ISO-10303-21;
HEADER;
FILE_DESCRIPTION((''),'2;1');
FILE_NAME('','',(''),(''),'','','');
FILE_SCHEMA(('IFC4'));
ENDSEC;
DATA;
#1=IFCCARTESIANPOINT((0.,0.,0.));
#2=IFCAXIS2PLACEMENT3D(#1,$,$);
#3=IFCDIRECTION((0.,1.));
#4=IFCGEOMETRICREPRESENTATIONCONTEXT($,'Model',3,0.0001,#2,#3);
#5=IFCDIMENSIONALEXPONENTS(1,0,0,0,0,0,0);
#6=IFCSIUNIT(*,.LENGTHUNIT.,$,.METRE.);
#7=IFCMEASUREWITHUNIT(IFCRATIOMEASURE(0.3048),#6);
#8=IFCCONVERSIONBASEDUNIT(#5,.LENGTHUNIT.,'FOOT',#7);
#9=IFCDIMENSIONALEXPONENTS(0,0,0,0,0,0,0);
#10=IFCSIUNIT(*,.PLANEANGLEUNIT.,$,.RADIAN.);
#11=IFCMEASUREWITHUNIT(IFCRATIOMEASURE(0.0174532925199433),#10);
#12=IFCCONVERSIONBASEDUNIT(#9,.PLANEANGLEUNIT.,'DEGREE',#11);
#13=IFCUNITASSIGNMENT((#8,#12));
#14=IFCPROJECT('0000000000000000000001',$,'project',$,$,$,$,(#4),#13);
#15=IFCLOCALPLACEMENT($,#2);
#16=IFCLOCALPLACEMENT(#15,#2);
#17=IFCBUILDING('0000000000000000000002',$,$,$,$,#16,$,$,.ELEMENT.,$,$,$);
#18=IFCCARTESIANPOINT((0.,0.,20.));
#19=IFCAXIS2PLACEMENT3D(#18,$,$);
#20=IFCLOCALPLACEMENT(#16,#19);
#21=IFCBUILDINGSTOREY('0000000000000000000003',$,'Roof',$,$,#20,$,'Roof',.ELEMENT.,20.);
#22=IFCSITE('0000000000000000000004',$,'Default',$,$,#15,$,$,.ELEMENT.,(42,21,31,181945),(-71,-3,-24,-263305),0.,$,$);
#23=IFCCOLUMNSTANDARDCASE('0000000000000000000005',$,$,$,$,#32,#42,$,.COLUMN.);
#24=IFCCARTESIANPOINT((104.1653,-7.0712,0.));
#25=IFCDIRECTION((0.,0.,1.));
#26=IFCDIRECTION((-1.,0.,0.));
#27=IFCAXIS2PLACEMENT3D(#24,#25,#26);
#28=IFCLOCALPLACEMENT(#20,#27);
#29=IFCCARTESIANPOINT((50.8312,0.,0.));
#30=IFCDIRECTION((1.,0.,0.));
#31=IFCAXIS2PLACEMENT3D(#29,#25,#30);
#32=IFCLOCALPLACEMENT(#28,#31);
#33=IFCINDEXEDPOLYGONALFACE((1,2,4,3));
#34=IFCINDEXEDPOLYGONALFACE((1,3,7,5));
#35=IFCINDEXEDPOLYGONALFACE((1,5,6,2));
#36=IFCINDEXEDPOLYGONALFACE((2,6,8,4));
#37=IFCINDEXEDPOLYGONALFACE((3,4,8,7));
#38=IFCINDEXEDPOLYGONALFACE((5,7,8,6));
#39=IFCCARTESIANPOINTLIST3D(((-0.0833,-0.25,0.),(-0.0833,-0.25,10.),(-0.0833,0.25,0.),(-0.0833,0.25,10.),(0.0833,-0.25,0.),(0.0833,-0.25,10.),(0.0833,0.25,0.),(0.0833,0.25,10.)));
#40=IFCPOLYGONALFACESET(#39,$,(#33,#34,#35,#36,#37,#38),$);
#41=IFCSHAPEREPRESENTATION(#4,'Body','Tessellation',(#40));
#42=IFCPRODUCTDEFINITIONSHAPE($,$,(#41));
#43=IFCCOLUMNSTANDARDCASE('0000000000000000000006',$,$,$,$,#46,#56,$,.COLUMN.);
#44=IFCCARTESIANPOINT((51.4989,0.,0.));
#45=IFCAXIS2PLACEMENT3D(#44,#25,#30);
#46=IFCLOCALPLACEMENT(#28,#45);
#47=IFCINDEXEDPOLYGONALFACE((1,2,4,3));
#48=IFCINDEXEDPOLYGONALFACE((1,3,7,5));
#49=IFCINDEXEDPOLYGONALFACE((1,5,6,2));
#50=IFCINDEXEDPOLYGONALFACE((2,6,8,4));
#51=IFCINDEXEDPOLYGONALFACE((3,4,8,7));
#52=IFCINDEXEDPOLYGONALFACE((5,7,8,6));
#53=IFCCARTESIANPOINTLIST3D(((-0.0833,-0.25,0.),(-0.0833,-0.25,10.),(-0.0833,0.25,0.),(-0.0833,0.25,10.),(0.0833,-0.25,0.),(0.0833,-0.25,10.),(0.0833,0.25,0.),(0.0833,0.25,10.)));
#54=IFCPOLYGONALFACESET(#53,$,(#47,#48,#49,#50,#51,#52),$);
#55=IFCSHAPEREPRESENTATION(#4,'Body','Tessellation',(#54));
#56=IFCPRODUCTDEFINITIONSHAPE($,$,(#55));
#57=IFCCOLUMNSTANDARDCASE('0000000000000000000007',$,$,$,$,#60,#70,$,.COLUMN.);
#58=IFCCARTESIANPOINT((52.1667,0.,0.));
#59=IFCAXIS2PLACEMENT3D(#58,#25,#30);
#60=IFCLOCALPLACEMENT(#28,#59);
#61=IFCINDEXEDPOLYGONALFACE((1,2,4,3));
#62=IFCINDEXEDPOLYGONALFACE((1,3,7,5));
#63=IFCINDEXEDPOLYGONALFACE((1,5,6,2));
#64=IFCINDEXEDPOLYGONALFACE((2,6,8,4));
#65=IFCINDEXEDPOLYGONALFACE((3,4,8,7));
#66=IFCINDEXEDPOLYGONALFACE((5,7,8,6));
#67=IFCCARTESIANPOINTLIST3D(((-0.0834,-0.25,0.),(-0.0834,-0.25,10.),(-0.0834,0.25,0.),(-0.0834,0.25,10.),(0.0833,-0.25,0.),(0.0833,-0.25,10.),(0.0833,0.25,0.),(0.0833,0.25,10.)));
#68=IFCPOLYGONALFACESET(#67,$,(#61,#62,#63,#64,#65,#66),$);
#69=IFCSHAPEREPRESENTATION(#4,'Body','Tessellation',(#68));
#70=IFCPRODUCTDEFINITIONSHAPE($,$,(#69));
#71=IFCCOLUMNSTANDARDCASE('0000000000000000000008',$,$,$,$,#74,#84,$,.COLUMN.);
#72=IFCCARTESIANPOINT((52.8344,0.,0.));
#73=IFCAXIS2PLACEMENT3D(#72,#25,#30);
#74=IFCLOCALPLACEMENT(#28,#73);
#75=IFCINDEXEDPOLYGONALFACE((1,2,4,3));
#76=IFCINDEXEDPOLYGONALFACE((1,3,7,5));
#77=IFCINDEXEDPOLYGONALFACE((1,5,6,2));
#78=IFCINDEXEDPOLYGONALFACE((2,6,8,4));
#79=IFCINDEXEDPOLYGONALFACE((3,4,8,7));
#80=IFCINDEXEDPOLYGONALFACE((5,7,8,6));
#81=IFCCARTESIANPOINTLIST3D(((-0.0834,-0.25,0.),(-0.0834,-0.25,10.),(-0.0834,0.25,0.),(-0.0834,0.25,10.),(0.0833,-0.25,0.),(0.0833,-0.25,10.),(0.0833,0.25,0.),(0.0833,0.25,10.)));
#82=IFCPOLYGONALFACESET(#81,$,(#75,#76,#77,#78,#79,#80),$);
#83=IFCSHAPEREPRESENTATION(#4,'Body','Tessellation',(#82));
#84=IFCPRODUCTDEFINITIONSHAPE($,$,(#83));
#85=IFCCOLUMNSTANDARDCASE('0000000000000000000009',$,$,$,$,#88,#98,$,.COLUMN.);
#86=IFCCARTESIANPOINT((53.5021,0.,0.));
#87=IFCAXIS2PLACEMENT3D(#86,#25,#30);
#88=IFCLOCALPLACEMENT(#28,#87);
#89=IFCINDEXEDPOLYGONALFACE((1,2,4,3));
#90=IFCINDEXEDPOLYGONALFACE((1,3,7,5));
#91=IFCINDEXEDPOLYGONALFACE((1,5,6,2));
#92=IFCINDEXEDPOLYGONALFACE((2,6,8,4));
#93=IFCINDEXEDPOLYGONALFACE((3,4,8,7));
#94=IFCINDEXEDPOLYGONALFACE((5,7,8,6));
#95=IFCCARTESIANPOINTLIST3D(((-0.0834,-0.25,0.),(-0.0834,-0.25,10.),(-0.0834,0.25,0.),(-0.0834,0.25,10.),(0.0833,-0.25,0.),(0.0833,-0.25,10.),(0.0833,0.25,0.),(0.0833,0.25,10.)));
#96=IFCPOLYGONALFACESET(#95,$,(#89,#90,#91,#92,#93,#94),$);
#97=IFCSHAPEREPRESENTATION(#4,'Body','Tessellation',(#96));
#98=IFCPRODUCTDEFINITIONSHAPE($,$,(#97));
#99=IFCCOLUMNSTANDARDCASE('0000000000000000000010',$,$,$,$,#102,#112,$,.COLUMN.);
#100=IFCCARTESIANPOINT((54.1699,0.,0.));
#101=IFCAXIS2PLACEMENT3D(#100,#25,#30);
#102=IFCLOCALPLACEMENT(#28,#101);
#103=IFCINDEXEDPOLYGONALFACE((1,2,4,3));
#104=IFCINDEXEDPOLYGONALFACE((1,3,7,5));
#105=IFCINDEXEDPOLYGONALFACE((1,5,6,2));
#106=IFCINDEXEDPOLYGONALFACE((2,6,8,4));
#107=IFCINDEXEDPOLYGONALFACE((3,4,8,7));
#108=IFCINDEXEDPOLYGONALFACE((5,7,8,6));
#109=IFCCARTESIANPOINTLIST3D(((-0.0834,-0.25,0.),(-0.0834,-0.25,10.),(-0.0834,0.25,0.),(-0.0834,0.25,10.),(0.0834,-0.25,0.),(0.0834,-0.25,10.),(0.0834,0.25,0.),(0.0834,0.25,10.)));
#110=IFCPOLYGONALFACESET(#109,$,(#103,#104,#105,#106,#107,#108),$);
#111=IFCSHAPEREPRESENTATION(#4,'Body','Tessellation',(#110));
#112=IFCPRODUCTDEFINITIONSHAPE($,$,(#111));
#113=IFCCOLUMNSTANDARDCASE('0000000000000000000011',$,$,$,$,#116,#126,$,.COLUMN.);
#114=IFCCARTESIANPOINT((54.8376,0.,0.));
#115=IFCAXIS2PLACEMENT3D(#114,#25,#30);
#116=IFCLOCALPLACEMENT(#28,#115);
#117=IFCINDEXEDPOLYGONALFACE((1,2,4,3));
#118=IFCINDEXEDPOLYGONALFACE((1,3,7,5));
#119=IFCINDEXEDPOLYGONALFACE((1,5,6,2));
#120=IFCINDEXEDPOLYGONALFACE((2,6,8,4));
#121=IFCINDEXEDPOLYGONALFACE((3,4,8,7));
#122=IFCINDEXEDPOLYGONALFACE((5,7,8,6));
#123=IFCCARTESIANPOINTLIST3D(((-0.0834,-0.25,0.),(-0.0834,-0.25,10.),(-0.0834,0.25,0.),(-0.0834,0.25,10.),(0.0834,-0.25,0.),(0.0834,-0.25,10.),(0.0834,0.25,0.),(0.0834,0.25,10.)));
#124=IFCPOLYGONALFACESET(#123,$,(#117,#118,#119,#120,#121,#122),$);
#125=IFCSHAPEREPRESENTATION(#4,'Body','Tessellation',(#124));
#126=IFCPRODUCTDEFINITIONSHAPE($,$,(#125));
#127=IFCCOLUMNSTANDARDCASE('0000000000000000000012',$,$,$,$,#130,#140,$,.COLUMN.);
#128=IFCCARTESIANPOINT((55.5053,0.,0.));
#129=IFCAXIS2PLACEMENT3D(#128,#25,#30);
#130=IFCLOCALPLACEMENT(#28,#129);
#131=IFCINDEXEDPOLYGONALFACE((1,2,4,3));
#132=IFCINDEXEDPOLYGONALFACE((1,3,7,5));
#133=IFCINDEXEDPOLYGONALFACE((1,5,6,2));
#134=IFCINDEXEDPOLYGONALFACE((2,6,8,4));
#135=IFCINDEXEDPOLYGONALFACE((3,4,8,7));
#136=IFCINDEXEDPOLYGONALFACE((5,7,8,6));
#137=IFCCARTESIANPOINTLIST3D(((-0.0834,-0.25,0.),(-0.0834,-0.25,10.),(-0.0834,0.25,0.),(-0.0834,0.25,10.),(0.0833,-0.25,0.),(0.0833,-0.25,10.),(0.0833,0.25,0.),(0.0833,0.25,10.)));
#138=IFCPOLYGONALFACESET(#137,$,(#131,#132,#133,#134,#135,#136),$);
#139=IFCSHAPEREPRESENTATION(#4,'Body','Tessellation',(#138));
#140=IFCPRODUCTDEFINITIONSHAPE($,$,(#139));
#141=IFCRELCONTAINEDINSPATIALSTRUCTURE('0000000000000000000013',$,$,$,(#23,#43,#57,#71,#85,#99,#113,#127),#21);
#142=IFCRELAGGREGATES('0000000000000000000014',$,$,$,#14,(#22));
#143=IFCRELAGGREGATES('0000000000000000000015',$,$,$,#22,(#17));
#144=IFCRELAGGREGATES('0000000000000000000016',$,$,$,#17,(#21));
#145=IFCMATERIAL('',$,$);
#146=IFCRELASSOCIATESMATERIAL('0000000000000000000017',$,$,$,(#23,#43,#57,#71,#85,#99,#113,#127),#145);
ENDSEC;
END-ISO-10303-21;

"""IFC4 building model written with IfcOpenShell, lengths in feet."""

from ifc_helpers import new_model, entity, si_unit, converted_unit, direction, frame, origin, place, context, project, spatial, rectangle, extrude, material, element, save


model = new_model("IFC4")

# Units and contexts
model_context = context("Model", 3, precision=0.0001, world=origin(), true_north=direction((0.0, 1.0)))
ifc_project = project(units=[converted_unit("LENGTHUNIT", "FOOT", entity("IfcRatioMeasure", 0.3048), si_unit("LENGTHUNIT", "METRE"), dimensions=[1, 0, 0, 0, 0, 0, 0]), converted_unit("PLANEANGLEUNIT", "DEGREE", entity("IfcRatioMeasure", 0.0174532925199433), si_unit("PLANEANGLEUNIT", "RADIAN"), dimensions=[0, 0, 0, 0, 0, 0, 0])], contexts=[model_context])

# Site, building, storey
site_placement = place(None, origin())
site = spatial("IfcSite", under=ifc_project, at=site_placement, Name="Default", CompositionType="ELEMENT", RefLatitude=(42, 21, 31, 181945), RefLongitude=(-71, -3, -24, -263305), RefElevation=0.0)
building_placement = place(site_placement, origin())
building = spatial("IfcBuilding", under=site, at=building_placement, CompositionType="ELEMENT")
storey_placement = place(building_placement, frame((0.0, 0.0, 20.0)))
storey = spatial("IfcBuildingStorey", under=building, at=storey_placement, Name="Roof", LongName="Roof", CompositionType="ELEMENT", Elevation=20.0)

# Columns
ifc_material_1 = material(Name="")
placement_1 = place(storey_placement, frame((104.1653, -7.0712, 0.0), z_axis=(0.0, 0.0, 1.0), x_axis=(-1.0, 0.0, 0.0)))
for number, where, z_axis, x_axis in (
    (1, (50.8312, 0.0, 0.0), (0.0, 0.0, 1.0), (1.0, 0.0, 0.0)),
    (2, (51.4989, 0.0, 0.0), (0.0, 0.0, 1.0), (1.0, 0.0, 0.0)),
    (3, (52.1667, 0.0, 0.0), (0.0, 0.0, 1.0), (1.0, 0.0, 0.0)),
    (4, (52.8344, 0.0, 0.0), (0.0, 0.0, 1.0), (1.0, 0.0, 0.0)),
    (5, (53.5021, 0.0, 0.0), (0.0, 0.0, 1.0), (1.0, 0.0, 0.0)),
    (6, (54.1699, 0.0, 0.0), (0.0, 0.0, 1.0), (1.0, 0.0, 0.0)),
    (7, (54.8376, 0.0, 0.0), (0.0, 0.0, 1.0), (1.0, 0.0, 0.0)),
    (8, (55.5053, 0.0, 0.0), (0.0, 0.0, 1.0), (1.0, 0.0, 0.0)),
):
    element("IfcColumnStandardCase", number, at=place(placement_1, frame(where, z_axis=z_axis, x_axis=x_axis)), inside=storey, material=ifc_material_1, PredefinedType="COLUMN", context=model_context, shape_type="SweptSolid", body=[
        extrude(rectangle(XDim=0.1667, YDim=0.5), origin(), (0.0, 0.0, 1.0), 10.0),
    ])

save(model, "model.ifc")
